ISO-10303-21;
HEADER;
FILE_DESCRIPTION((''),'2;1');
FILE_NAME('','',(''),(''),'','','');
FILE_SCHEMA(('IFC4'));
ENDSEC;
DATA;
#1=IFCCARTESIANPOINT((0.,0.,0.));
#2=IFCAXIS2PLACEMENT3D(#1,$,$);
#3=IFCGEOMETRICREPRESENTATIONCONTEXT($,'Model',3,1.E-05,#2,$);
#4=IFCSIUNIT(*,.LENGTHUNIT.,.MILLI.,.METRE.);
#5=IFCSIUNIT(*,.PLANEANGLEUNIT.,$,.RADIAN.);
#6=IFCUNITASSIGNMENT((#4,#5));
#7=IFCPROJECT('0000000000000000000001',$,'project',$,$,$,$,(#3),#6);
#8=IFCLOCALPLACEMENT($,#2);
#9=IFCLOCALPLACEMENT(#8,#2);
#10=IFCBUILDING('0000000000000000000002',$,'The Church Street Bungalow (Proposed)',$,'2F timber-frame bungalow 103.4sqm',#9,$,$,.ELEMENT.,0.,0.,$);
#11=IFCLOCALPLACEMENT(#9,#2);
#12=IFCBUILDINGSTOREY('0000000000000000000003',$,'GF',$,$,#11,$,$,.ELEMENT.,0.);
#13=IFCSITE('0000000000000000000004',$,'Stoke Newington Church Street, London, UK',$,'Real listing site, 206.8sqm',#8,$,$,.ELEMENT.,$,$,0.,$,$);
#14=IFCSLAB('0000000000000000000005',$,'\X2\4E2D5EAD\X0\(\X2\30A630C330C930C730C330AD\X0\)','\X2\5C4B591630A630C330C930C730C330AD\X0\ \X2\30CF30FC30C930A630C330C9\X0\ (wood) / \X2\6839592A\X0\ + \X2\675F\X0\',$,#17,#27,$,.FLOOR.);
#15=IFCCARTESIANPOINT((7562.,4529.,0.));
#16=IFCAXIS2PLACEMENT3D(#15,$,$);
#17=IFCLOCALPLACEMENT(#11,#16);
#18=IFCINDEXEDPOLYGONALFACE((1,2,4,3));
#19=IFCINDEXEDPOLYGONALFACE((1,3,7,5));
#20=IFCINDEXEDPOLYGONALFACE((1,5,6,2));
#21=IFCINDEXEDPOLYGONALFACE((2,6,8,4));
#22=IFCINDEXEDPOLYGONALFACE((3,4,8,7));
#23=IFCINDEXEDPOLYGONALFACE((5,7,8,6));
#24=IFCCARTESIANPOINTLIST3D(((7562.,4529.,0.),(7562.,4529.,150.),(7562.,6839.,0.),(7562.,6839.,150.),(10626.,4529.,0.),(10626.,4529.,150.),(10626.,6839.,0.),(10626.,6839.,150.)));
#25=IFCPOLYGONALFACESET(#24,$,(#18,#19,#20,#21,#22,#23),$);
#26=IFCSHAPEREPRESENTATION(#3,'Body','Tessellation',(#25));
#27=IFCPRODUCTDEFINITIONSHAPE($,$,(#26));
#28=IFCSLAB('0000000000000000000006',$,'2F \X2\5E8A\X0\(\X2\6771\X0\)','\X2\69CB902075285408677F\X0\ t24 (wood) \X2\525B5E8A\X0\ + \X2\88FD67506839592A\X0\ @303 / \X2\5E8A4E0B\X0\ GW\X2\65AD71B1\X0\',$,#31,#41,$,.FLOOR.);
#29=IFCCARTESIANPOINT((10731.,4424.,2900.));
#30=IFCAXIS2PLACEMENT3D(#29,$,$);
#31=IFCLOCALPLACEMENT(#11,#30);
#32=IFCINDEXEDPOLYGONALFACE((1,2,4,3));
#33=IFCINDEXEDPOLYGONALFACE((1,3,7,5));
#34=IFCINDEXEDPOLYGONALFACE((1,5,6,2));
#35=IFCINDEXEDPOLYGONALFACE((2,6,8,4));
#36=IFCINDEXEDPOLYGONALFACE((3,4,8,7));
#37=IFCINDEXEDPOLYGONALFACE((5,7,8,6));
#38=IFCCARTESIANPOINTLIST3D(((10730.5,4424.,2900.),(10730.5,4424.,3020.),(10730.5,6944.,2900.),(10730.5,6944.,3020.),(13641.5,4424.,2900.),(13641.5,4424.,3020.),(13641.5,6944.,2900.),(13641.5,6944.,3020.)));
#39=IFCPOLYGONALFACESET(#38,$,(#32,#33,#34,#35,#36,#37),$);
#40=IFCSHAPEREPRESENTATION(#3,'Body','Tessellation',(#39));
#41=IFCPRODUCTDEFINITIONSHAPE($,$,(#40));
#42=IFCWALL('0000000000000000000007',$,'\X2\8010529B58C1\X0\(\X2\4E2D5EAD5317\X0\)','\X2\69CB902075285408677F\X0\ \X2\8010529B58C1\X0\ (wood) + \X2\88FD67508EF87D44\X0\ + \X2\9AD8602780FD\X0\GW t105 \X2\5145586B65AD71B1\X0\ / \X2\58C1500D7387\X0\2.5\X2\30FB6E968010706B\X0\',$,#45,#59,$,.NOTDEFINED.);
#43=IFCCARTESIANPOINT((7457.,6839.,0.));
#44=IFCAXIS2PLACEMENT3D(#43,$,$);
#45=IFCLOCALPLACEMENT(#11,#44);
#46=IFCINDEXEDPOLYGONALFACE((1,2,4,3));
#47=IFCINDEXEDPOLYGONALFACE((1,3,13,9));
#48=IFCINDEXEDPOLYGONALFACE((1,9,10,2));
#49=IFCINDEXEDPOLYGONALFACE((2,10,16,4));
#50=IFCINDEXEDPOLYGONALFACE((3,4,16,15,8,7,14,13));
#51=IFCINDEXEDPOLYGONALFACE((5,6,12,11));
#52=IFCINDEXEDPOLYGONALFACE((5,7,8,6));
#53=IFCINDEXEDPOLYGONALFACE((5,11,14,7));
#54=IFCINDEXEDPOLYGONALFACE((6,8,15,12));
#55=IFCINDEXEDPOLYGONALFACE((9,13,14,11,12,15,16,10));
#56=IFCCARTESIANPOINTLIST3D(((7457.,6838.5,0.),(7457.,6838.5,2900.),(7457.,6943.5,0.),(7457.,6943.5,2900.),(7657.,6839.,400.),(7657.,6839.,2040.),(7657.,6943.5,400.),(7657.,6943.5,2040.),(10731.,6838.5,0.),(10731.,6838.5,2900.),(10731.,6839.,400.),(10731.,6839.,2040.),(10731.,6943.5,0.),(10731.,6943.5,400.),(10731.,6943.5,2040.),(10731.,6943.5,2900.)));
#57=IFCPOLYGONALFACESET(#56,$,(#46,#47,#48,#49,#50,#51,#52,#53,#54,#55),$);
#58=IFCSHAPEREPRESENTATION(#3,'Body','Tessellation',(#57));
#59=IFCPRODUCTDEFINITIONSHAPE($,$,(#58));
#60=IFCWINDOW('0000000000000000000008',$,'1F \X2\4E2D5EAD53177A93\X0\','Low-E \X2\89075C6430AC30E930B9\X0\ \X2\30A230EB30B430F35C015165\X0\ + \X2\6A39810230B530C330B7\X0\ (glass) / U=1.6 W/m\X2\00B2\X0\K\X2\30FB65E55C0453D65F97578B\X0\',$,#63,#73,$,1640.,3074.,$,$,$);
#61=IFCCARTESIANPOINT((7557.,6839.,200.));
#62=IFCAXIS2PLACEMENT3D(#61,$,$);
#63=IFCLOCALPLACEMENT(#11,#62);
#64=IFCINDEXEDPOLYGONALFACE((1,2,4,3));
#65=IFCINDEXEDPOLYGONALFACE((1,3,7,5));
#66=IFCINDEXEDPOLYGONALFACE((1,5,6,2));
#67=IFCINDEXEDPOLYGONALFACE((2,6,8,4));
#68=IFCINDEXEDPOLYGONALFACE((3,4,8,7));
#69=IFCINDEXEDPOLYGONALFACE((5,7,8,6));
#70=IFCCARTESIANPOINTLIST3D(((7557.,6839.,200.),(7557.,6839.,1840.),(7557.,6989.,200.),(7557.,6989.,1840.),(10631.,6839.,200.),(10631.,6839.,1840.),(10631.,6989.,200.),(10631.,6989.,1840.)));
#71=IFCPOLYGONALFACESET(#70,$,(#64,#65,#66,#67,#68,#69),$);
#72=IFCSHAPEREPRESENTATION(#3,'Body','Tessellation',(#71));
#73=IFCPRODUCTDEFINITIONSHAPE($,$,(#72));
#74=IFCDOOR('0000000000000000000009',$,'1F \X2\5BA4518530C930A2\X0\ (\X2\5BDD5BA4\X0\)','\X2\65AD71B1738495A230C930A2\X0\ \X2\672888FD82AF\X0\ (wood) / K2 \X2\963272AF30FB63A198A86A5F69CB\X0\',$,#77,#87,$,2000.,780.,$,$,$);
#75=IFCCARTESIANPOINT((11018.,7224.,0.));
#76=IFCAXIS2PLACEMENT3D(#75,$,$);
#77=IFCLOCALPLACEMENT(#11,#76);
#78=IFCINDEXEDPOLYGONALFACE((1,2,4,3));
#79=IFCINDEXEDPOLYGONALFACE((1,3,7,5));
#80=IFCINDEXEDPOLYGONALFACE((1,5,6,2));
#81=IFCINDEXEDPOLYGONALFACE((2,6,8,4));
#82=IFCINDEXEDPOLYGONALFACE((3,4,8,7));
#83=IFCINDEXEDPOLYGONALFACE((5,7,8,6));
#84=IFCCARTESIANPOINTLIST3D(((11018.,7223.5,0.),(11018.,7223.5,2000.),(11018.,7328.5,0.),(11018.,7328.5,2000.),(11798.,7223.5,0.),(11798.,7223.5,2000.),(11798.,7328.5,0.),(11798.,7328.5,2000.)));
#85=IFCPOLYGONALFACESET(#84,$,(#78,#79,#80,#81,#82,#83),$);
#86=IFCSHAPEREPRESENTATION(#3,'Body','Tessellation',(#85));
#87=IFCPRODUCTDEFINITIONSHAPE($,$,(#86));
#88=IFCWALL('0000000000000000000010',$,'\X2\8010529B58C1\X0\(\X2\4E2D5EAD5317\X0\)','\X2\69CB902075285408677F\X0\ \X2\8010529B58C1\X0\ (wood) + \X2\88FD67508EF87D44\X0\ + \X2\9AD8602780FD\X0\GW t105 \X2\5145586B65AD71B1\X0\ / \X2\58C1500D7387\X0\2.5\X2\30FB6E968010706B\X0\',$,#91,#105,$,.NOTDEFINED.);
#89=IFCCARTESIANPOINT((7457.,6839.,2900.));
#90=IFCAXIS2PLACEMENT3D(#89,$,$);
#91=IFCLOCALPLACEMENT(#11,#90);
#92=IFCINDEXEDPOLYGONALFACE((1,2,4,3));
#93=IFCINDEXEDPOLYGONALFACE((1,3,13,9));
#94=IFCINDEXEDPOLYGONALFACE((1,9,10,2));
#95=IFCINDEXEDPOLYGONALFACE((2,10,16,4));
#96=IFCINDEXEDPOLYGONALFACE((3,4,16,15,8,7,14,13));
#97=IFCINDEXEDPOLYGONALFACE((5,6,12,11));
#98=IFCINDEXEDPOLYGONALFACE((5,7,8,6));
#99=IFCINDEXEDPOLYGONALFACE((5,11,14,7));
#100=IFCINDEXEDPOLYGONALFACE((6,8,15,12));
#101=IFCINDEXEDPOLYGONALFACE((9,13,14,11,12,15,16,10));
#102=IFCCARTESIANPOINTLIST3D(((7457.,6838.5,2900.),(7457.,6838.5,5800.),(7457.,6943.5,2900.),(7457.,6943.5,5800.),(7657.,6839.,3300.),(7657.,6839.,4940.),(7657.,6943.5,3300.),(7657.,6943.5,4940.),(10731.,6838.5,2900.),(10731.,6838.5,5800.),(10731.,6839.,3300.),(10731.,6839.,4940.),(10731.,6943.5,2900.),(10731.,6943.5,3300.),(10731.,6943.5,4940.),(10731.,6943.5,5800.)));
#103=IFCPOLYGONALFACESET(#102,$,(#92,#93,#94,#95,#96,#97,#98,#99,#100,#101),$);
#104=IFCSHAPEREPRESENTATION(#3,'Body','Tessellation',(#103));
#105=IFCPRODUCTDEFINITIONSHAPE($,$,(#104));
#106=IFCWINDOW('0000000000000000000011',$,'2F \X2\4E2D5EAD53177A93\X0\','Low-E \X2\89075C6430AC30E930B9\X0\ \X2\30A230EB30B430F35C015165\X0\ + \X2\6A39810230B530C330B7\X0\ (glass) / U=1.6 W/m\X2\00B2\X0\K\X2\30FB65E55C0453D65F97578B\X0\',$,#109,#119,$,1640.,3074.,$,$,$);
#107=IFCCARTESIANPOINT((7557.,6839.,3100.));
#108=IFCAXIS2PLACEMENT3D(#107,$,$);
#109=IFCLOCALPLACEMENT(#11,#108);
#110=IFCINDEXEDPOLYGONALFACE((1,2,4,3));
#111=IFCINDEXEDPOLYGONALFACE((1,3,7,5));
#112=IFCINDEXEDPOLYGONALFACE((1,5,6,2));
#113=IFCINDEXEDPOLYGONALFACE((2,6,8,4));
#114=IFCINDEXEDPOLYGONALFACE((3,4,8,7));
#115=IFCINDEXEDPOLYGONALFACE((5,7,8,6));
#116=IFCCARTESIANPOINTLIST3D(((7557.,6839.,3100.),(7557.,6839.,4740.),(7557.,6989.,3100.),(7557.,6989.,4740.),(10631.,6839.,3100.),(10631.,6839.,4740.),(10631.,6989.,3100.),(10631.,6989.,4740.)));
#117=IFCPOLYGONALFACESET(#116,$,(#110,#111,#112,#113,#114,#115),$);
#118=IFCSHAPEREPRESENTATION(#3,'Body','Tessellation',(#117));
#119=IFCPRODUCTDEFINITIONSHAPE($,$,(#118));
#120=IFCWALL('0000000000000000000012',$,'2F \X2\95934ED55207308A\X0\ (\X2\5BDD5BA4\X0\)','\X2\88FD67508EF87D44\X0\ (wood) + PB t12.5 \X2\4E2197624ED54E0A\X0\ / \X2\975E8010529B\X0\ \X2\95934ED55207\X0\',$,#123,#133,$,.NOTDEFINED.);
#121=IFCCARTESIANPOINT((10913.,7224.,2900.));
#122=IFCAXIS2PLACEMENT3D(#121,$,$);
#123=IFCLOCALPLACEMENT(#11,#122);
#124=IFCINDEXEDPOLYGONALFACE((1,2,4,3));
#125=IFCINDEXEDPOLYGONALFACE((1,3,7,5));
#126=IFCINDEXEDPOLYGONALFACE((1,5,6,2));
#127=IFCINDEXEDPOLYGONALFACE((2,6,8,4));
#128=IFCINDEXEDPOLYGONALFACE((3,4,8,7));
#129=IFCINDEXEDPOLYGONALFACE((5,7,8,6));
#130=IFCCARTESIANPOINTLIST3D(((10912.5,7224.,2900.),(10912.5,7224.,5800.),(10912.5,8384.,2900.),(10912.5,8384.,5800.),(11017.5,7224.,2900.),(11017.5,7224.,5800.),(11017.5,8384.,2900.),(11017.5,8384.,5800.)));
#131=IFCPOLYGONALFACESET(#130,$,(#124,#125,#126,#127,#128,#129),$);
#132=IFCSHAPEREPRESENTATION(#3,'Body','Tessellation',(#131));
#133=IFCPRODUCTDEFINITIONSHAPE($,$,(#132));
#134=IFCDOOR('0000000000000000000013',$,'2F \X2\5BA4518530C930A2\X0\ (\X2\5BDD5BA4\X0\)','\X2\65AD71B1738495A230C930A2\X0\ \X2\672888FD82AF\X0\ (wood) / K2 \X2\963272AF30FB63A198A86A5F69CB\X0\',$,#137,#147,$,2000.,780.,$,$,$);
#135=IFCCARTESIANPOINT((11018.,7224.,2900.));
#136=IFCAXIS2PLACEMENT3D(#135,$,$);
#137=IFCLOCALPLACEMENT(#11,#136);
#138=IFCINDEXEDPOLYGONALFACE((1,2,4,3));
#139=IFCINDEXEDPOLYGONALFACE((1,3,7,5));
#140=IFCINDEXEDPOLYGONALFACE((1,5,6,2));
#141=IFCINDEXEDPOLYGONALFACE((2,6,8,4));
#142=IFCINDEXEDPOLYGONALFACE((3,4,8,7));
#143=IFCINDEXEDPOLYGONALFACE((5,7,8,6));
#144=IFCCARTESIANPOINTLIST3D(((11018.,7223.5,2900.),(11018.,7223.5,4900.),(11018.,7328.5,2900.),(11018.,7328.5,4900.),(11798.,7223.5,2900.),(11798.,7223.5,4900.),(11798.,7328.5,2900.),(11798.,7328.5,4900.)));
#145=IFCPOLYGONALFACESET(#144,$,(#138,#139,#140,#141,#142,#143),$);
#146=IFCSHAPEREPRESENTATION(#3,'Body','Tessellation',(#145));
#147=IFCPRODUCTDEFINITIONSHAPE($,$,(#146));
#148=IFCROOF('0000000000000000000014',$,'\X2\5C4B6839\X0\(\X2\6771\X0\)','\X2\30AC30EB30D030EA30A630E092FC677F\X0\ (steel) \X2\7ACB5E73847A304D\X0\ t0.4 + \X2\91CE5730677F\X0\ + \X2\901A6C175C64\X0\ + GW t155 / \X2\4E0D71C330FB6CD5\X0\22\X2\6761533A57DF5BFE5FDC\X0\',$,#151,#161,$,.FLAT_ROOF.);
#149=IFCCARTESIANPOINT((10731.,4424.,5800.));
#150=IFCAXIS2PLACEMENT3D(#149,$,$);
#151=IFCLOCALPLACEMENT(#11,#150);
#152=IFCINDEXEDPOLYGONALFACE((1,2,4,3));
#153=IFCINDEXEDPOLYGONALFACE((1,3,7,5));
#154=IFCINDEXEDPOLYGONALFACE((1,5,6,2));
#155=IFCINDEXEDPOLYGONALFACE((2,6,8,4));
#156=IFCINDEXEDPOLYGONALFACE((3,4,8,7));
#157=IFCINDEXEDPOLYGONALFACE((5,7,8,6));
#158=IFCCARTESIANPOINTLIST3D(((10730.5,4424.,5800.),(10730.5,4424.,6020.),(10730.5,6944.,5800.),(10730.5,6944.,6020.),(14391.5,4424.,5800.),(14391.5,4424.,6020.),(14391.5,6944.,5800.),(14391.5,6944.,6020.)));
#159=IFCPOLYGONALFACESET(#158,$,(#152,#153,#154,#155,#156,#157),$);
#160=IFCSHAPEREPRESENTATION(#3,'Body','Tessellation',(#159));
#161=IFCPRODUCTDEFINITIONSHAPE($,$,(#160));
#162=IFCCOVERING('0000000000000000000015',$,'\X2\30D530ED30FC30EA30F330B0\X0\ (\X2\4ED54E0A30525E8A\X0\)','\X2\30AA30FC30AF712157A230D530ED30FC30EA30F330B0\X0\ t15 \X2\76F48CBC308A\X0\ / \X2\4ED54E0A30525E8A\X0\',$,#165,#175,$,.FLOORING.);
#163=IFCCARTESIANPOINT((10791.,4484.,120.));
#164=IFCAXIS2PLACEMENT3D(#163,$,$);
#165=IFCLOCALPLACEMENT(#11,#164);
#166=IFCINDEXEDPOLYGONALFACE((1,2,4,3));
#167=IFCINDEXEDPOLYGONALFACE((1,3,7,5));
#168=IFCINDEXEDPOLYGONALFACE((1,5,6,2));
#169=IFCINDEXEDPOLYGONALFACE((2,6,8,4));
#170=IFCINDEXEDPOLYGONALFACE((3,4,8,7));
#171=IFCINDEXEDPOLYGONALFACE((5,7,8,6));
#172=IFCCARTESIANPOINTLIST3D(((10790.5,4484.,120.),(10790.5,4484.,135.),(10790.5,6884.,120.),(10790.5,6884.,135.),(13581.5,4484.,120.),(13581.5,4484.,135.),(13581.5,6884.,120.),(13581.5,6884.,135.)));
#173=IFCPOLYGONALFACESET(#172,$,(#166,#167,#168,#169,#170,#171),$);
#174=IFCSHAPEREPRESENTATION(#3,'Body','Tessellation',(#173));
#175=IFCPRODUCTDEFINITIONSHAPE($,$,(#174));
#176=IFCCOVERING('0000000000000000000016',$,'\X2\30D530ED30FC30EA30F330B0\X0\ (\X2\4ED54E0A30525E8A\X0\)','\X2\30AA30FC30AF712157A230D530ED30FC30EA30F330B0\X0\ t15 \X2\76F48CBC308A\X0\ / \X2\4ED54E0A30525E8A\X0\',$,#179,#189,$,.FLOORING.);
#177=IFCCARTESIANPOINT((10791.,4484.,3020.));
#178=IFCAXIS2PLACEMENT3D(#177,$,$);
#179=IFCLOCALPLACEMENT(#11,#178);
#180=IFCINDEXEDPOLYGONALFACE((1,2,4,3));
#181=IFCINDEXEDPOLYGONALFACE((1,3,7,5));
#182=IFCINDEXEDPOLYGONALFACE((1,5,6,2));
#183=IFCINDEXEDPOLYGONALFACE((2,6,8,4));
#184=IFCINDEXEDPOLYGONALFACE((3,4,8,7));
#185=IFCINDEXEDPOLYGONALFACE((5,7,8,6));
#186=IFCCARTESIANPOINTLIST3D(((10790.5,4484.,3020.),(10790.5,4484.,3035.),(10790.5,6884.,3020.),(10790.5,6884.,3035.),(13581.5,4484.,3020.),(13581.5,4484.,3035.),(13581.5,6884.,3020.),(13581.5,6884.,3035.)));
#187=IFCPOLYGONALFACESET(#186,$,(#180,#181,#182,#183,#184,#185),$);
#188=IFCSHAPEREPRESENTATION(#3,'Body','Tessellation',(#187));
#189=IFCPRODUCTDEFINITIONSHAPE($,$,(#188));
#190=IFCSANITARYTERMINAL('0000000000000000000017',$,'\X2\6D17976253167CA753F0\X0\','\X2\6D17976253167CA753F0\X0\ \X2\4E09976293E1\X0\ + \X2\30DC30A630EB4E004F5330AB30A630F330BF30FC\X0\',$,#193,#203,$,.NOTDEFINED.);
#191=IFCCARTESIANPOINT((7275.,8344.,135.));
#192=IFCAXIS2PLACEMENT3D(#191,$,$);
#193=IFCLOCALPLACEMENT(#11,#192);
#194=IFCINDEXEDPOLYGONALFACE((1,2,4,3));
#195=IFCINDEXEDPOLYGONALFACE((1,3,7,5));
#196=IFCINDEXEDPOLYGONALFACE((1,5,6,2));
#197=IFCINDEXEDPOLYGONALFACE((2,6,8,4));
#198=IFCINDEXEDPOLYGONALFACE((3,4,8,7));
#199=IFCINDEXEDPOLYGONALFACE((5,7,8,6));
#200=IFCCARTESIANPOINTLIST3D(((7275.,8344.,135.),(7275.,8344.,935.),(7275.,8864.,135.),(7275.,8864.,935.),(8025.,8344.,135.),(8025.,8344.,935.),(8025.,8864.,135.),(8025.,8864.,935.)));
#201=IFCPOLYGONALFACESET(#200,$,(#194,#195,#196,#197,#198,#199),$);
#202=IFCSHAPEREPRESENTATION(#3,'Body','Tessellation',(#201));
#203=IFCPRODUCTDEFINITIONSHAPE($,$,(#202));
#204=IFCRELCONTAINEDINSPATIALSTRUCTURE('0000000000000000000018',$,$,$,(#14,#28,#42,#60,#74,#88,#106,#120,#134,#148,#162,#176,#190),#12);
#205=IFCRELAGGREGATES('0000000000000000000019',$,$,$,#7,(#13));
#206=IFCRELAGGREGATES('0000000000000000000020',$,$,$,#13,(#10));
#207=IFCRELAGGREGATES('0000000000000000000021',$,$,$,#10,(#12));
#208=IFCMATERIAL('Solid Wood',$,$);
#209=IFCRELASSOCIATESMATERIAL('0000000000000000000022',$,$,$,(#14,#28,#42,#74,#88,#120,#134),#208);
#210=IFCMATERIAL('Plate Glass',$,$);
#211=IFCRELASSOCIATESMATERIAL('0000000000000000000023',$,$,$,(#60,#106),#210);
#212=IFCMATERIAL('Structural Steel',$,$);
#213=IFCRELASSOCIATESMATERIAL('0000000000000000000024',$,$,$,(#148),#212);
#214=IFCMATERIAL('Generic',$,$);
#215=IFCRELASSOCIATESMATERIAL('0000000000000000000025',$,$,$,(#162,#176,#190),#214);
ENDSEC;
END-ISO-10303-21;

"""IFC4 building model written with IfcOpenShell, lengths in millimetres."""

from ifc_helpers import new_model, si_unit, frame, frame_2d, origin, place, context, project, spatial, rectangle, extrude, material, element, fill, save


model = new_model("IFC4")

# Units and contexts
model_context = context("Model", 3, precision=1e-05, world=origin())
ifc_project = project(units=[si_unit("LENGTHUNIT", "METRE", prefix="MILLI"), si_unit("PLANEANGLEUNIT", "RADIAN")], contexts=[model_context])

# Site, building, storey
site_placement = place(None, origin())
site = spatial("IfcSite", under=ifc_project, at=site_placement, Name="Stoke Newington Church Street, London, UK", ObjectType="Real listing site, 206.8sqm", CompositionType="ELEMENT", RefElevation=0.0)
building_placement = place(site_placement, origin())
building = spatial("IfcBuilding", under=site, at=building_placement, Name="The Church Street Bungalow (Proposed)", ObjectType="2F timber-frame bungalow 103.4sqm", CompositionType="ELEMENT", ElevationOfRefHeight=0.0, ElevationOfTerrain=0.0)
storey_placement = place(building_placement, origin())
storey = spatial("IfcBuildingStorey", under=building, at=storey_placement, Name="GF", CompositionType="ELEMENT", Elevation=0.0)

# Slabs
ifc_material_1 = material(Name="Solid Wood")
slab_1_placement = place(storey_placement, frame((7562.0, 4529.0, 0.0)))
element("IfcSlab", 1, at=slab_1_placement, inside=storey, material=ifc_material_1, Name="中庭(ウッドデッキ)", Description="屋外ウッドデッキ ハードウッド (wood) / 根太 + 束", PredefinedType="FLOOR", context=model_context, shape_type="SweptSolid", body=[
    extrude(rectangle(XDim=3064.0, YDim=2310.0, at=frame_2d((1532.0, 1155.0))), frame((7562.0, 4529.0, 0.0)), (0.0, 0.0, 1.0), 150.0),
])
slab_2_placement = place(storey_placement, frame((10731.0, 4424.0, 2900.0)))
element("IfcSlab", 2, at=slab_2_placement, inside=storey, material=ifc_material_1, Name="2F 床(東)", Description="構造用合板 t24 (wood) 剛床 + 製材根太 @303 / 床下 GW断熱", PredefinedType="FLOOR", context=model_context, shape_type="SweptSolid", body=[
    extrude(rectangle(XDim=2911.0, YDim=2520.0, at=frame_2d((1455.0, 1260.0))), frame((10731.0, 4424.0, 2900.0)), (0.0, 0.0, 1.0), 120.0),
])

# Wall, opening, window
wall_1_placement = place(storey_placement, frame((7457.0, 6839.0, 0.0)))
wall_1 = element("IfcWall", 3, at=wall_1_placement, inside=storey, material=ifc_material_1, Name="耐力壁(中庭北)", Description="構造用合板 耐力壁 (wood) + 製材軸組 + 高性能GW t105 充填断熱 / 壁倍率2.5・準耐火", PredefinedType="NOTDEFINED", context=model_context, shape_type="SweptSolid", body=[
    extrude(rectangle(XDim=3274.0, YDim=105.0, at=frame_2d((1637.0, 52.0))), frame((7457.0, 6839.0, 0.0)), (0.0, 0.0, 1.0), 2900.0),
])
opening_1_placement = place(storey_placement, frame((7557.0, 6839.0, 200.0)))
opening_1 = element("IfcOpeningElement", 4, at=opening_1_placement, cuts=wall_1, PredefinedType="NOTDEFINED", context=model_context, shape_type="SweptSolid", body=[
    extrude(rectangle(XDim=3074.0, YDim=150.0, at=frame_2d((1537.0, 75.0))), frame((7557.0, 6839.0, 200.0)), (0.0, 0.0, 1.0), 1640.0),
])
ifc_material_2 = material(Name="Plate Glass")
window_1_placement = place(storey_placement, frame((7557.0, 6839.0, 200.0)))
window_1 = element("IfcWindow", 5, at=window_1_placement, inside=storey, material=ifc_material_2, Name="1F 中庭北窓", Description="Low-E 複層ガラス アルゴン封入 + 樹脂サッシ (glass) / U=1.6 W/m²K・日射取得型", OverallHeight=1640.0, OverallWidth=3074.0, context=model_context, shape_type="SweptSolid", body=[
    extrude(rectangle(XDim=3074.0, YDim=150.0, at=frame_2d((1537.0, 75.0))), frame((7557.0, 6839.0, 200.0)), (0.0, 0.0, 1.0), 1640.0),
])
fill(opening_1, window_1)

# Door
door_1_placement = place(storey_placement, frame((11018.0, 7224.0, 0.0)))
element("IfcDoor", 6, at=door_1_placement, inside=storey, material=ifc_material_1, Name="1F 室内ドア (寝室)", Description="断熱玄関ドア 木製芯 (wood) / K2 防犯・採風機構", OverallHeight=2000.0, OverallWidth=780.0, context=model_context, shape_type="SweptSolid", body=[
    extrude(rectangle(XDim=780.0, YDim=105.0, at=frame_2d((390.0, 52.0))), frame((11018.0, 7224.0, 0.0)), (0.0, 0.0, 1.0), 2000.0),
])

# Wall, opening, window
wall_2_placement = place(storey_placement, frame((7457.0, 6839.0, 2900.0)))
wall_2 = element("IfcWall", 7, at=wall_2_placement, inside=storey, material=ifc_material_1, Name="耐力壁(中庭北)", Description="構造用合板 耐力壁 (wood) + 製材軸組 + 高性能GW t105 充填断熱 / 壁倍率2.5・準耐火", PredefinedType="NOTDEFINED", context=model_context, shape_type="SweptSolid", body=[
    extrude(rectangle(XDim=3274.0, YDim=105.0, at=frame_2d((1637.0, 52.0))), frame((7457.0, 6839.0, 2900.0)), (0.0, 0.0, 1.0), 2900.0),
])
opening_2_placement = place(storey_placement, frame((7557.0, 6839.0, 3100.0)))
opening_2 = element("IfcOpeningElement", 8, at=opening_2_placement, cuts=wall_2, PredefinedType="NOTDEFINED", context=model_context, shape_type="SweptSolid", body=[
    extrude(rectangle(XDim=3074.0, YDim=150.0, at=frame_2d((1537.0, 75.0))), frame((7557.0, 6839.0, 3100.0)), (0.0, 0.0, 1.0), 1640.0),
])
window_2_placement = place(storey_placement, frame((7557.0, 6839.0, 3100.0)))
window_2 = element("IfcWindow", 9, at=window_2_placement, inside=storey, material=ifc_material_2, Name="2F 中庭北窓", Description="Low-E 複層ガラス アルゴン封入 + 樹脂サッシ (glass) / U=1.6 W/m²K・日射取得型", OverallHeight=1640.0, OverallWidth=3074.0, context=model_context, shape_type="SweptSolid", body=[
    extrude(rectangle(XDim=3074.0, YDim=150.0, at=frame_2d((1537.0, 75.0))), frame((7557.0, 6839.0, 3100.0)), (0.0, 0.0, 1.0), 1640.0),
])
fill(opening_2, window_2)

# Wall
wall_3_placement = place(storey_placement, frame((10913.0, 7224.0, 2900.0)))
element("IfcWall", 10, at=wall_3_placement, inside=storey, material=ifc_material_1, Name="2F 間仕切り (寝室)", Description="製材軸組 (wood) + PB t12.5 両面仕上 / 非耐力 間仕切", PredefinedType="NOTDEFINED", context=model_context, shape_type="SweptSolid", body=[
    extrude(rectangle(XDim=105.0, YDim=1160.0, at=frame_2d((52.0, 580.0))), frame((10913.0, 7224.0, 2900.0)), (0.0, 0.0, 1.0), 2900.0),
])

# Door
door_2_placement = place(storey_placement, frame((11018.0, 7224.0, 2900.0)))
element("IfcDoor", 11, at=door_2_placement, inside=storey, material=ifc_material_1, Name="2F 室内ドア (寝室)", Description="断熱玄関ドア 木製芯 (wood) / K2 防犯・採風機構", OverallHeight=2000.0, OverallWidth=780.0, context=model_context, shape_type="SweptSolid", body=[
    extrude(rectangle(XDim=780.0, YDim=105.0, at=frame_2d((390.0, 52.0))), frame((11018.0, 7224.0, 2900.0)), (0.0, 0.0, 1.0), 2000.0),
])

# Roof
ifc_material_3 = material(Name="Structural Steel")
for number, where, name in (
    (12, (10731.0, 4424.0, 5800.0), "屋根(東)"),
):
    element("IfcRoof", number, at=place(storey_placement, frame(where)), inside=storey, material=ifc_material_3, Name=name, Description="ガルバリウム鋼板 (steel) 立平葺き t0.4 + 野地板 + 通気層 + GW t155 / 不燃・法22条区域対応", PredefinedType="FLAT_ROOF", context=model_context, shape_type="SweptSolid", body=[
        extrude(rectangle(XDim=3661.0, YDim=2520.0, at=frame_2d((1830.0, 1260.0))), frame((10731.0, 4424.0, 5800.0)), (0.0, 0.0, 1.0), 220.0),
    ])

# Coverings
ifc_material_4 = material(Name="Generic")
covering_1_placement = place(storey_placement, frame((10791.0, 4484.0, 120.0)))
element("IfcCovering", 13, at=covering_1_placement, inside=storey, material=ifc_material_4, Name="フローリング (仕上げ床)", Description="オーク無垢フローリング t15 直貼り / 仕上げ床", PredefinedType="FLOORING", context=model_context, shape_type="SweptSolid", body=[
    extrude(rectangle(XDim=2791.0, YDim=2400.0, at=frame_2d((1395.0, 1200.0))), frame((10791.0, 4484.0, 120.0)), (0.0, 0.0, 1.0), 15.0),
])
covering_2_placement = place(storey_placement, frame((10791.0, 4484.0, 3020.0)))
element("IfcCovering", 14, at=covering_2_placement, inside=storey, material=ifc_material_4, Name="フローリング (仕上げ床)", Description="オーク無垢フローリング t15 直貼り / 仕上げ床", PredefinedType="FLOORING", context=model_context, shape_type="SweptSolid", body=[
    extrude(rectangle(XDim=2791.0, YDim=2400.0, at=frame_2d((1395.0, 1200.0))), frame((10791.0, 4484.0, 3020.0)), (0.0, 0.0, 1.0), 15.0),
])

# Sanitary terminal
sanitary_terminal_1_placement = place(storey_placement, frame((7275.0, 8344.0, 135.0)))
element("IfcSanitaryTerminal", 15, at=sanitary_terminal_1_placement, inside=storey, material=ifc_material_4, Name="洗面化粧台", Description="洗面化粧台 三面鏡 + ボウル一体カウンター", PredefinedType="NOTDEFINED", context=model_context, shape_type="SweptSolid", body=[
    extrude(rectangle(XDim=750.0, YDim=520.0, at=frame_2d((375.0, 260.0))), frame((7275.0, 8344.0, 135.0)), (0.0, 0.0, 1.0), 800.0),
])

save(model, "model.ifc")
